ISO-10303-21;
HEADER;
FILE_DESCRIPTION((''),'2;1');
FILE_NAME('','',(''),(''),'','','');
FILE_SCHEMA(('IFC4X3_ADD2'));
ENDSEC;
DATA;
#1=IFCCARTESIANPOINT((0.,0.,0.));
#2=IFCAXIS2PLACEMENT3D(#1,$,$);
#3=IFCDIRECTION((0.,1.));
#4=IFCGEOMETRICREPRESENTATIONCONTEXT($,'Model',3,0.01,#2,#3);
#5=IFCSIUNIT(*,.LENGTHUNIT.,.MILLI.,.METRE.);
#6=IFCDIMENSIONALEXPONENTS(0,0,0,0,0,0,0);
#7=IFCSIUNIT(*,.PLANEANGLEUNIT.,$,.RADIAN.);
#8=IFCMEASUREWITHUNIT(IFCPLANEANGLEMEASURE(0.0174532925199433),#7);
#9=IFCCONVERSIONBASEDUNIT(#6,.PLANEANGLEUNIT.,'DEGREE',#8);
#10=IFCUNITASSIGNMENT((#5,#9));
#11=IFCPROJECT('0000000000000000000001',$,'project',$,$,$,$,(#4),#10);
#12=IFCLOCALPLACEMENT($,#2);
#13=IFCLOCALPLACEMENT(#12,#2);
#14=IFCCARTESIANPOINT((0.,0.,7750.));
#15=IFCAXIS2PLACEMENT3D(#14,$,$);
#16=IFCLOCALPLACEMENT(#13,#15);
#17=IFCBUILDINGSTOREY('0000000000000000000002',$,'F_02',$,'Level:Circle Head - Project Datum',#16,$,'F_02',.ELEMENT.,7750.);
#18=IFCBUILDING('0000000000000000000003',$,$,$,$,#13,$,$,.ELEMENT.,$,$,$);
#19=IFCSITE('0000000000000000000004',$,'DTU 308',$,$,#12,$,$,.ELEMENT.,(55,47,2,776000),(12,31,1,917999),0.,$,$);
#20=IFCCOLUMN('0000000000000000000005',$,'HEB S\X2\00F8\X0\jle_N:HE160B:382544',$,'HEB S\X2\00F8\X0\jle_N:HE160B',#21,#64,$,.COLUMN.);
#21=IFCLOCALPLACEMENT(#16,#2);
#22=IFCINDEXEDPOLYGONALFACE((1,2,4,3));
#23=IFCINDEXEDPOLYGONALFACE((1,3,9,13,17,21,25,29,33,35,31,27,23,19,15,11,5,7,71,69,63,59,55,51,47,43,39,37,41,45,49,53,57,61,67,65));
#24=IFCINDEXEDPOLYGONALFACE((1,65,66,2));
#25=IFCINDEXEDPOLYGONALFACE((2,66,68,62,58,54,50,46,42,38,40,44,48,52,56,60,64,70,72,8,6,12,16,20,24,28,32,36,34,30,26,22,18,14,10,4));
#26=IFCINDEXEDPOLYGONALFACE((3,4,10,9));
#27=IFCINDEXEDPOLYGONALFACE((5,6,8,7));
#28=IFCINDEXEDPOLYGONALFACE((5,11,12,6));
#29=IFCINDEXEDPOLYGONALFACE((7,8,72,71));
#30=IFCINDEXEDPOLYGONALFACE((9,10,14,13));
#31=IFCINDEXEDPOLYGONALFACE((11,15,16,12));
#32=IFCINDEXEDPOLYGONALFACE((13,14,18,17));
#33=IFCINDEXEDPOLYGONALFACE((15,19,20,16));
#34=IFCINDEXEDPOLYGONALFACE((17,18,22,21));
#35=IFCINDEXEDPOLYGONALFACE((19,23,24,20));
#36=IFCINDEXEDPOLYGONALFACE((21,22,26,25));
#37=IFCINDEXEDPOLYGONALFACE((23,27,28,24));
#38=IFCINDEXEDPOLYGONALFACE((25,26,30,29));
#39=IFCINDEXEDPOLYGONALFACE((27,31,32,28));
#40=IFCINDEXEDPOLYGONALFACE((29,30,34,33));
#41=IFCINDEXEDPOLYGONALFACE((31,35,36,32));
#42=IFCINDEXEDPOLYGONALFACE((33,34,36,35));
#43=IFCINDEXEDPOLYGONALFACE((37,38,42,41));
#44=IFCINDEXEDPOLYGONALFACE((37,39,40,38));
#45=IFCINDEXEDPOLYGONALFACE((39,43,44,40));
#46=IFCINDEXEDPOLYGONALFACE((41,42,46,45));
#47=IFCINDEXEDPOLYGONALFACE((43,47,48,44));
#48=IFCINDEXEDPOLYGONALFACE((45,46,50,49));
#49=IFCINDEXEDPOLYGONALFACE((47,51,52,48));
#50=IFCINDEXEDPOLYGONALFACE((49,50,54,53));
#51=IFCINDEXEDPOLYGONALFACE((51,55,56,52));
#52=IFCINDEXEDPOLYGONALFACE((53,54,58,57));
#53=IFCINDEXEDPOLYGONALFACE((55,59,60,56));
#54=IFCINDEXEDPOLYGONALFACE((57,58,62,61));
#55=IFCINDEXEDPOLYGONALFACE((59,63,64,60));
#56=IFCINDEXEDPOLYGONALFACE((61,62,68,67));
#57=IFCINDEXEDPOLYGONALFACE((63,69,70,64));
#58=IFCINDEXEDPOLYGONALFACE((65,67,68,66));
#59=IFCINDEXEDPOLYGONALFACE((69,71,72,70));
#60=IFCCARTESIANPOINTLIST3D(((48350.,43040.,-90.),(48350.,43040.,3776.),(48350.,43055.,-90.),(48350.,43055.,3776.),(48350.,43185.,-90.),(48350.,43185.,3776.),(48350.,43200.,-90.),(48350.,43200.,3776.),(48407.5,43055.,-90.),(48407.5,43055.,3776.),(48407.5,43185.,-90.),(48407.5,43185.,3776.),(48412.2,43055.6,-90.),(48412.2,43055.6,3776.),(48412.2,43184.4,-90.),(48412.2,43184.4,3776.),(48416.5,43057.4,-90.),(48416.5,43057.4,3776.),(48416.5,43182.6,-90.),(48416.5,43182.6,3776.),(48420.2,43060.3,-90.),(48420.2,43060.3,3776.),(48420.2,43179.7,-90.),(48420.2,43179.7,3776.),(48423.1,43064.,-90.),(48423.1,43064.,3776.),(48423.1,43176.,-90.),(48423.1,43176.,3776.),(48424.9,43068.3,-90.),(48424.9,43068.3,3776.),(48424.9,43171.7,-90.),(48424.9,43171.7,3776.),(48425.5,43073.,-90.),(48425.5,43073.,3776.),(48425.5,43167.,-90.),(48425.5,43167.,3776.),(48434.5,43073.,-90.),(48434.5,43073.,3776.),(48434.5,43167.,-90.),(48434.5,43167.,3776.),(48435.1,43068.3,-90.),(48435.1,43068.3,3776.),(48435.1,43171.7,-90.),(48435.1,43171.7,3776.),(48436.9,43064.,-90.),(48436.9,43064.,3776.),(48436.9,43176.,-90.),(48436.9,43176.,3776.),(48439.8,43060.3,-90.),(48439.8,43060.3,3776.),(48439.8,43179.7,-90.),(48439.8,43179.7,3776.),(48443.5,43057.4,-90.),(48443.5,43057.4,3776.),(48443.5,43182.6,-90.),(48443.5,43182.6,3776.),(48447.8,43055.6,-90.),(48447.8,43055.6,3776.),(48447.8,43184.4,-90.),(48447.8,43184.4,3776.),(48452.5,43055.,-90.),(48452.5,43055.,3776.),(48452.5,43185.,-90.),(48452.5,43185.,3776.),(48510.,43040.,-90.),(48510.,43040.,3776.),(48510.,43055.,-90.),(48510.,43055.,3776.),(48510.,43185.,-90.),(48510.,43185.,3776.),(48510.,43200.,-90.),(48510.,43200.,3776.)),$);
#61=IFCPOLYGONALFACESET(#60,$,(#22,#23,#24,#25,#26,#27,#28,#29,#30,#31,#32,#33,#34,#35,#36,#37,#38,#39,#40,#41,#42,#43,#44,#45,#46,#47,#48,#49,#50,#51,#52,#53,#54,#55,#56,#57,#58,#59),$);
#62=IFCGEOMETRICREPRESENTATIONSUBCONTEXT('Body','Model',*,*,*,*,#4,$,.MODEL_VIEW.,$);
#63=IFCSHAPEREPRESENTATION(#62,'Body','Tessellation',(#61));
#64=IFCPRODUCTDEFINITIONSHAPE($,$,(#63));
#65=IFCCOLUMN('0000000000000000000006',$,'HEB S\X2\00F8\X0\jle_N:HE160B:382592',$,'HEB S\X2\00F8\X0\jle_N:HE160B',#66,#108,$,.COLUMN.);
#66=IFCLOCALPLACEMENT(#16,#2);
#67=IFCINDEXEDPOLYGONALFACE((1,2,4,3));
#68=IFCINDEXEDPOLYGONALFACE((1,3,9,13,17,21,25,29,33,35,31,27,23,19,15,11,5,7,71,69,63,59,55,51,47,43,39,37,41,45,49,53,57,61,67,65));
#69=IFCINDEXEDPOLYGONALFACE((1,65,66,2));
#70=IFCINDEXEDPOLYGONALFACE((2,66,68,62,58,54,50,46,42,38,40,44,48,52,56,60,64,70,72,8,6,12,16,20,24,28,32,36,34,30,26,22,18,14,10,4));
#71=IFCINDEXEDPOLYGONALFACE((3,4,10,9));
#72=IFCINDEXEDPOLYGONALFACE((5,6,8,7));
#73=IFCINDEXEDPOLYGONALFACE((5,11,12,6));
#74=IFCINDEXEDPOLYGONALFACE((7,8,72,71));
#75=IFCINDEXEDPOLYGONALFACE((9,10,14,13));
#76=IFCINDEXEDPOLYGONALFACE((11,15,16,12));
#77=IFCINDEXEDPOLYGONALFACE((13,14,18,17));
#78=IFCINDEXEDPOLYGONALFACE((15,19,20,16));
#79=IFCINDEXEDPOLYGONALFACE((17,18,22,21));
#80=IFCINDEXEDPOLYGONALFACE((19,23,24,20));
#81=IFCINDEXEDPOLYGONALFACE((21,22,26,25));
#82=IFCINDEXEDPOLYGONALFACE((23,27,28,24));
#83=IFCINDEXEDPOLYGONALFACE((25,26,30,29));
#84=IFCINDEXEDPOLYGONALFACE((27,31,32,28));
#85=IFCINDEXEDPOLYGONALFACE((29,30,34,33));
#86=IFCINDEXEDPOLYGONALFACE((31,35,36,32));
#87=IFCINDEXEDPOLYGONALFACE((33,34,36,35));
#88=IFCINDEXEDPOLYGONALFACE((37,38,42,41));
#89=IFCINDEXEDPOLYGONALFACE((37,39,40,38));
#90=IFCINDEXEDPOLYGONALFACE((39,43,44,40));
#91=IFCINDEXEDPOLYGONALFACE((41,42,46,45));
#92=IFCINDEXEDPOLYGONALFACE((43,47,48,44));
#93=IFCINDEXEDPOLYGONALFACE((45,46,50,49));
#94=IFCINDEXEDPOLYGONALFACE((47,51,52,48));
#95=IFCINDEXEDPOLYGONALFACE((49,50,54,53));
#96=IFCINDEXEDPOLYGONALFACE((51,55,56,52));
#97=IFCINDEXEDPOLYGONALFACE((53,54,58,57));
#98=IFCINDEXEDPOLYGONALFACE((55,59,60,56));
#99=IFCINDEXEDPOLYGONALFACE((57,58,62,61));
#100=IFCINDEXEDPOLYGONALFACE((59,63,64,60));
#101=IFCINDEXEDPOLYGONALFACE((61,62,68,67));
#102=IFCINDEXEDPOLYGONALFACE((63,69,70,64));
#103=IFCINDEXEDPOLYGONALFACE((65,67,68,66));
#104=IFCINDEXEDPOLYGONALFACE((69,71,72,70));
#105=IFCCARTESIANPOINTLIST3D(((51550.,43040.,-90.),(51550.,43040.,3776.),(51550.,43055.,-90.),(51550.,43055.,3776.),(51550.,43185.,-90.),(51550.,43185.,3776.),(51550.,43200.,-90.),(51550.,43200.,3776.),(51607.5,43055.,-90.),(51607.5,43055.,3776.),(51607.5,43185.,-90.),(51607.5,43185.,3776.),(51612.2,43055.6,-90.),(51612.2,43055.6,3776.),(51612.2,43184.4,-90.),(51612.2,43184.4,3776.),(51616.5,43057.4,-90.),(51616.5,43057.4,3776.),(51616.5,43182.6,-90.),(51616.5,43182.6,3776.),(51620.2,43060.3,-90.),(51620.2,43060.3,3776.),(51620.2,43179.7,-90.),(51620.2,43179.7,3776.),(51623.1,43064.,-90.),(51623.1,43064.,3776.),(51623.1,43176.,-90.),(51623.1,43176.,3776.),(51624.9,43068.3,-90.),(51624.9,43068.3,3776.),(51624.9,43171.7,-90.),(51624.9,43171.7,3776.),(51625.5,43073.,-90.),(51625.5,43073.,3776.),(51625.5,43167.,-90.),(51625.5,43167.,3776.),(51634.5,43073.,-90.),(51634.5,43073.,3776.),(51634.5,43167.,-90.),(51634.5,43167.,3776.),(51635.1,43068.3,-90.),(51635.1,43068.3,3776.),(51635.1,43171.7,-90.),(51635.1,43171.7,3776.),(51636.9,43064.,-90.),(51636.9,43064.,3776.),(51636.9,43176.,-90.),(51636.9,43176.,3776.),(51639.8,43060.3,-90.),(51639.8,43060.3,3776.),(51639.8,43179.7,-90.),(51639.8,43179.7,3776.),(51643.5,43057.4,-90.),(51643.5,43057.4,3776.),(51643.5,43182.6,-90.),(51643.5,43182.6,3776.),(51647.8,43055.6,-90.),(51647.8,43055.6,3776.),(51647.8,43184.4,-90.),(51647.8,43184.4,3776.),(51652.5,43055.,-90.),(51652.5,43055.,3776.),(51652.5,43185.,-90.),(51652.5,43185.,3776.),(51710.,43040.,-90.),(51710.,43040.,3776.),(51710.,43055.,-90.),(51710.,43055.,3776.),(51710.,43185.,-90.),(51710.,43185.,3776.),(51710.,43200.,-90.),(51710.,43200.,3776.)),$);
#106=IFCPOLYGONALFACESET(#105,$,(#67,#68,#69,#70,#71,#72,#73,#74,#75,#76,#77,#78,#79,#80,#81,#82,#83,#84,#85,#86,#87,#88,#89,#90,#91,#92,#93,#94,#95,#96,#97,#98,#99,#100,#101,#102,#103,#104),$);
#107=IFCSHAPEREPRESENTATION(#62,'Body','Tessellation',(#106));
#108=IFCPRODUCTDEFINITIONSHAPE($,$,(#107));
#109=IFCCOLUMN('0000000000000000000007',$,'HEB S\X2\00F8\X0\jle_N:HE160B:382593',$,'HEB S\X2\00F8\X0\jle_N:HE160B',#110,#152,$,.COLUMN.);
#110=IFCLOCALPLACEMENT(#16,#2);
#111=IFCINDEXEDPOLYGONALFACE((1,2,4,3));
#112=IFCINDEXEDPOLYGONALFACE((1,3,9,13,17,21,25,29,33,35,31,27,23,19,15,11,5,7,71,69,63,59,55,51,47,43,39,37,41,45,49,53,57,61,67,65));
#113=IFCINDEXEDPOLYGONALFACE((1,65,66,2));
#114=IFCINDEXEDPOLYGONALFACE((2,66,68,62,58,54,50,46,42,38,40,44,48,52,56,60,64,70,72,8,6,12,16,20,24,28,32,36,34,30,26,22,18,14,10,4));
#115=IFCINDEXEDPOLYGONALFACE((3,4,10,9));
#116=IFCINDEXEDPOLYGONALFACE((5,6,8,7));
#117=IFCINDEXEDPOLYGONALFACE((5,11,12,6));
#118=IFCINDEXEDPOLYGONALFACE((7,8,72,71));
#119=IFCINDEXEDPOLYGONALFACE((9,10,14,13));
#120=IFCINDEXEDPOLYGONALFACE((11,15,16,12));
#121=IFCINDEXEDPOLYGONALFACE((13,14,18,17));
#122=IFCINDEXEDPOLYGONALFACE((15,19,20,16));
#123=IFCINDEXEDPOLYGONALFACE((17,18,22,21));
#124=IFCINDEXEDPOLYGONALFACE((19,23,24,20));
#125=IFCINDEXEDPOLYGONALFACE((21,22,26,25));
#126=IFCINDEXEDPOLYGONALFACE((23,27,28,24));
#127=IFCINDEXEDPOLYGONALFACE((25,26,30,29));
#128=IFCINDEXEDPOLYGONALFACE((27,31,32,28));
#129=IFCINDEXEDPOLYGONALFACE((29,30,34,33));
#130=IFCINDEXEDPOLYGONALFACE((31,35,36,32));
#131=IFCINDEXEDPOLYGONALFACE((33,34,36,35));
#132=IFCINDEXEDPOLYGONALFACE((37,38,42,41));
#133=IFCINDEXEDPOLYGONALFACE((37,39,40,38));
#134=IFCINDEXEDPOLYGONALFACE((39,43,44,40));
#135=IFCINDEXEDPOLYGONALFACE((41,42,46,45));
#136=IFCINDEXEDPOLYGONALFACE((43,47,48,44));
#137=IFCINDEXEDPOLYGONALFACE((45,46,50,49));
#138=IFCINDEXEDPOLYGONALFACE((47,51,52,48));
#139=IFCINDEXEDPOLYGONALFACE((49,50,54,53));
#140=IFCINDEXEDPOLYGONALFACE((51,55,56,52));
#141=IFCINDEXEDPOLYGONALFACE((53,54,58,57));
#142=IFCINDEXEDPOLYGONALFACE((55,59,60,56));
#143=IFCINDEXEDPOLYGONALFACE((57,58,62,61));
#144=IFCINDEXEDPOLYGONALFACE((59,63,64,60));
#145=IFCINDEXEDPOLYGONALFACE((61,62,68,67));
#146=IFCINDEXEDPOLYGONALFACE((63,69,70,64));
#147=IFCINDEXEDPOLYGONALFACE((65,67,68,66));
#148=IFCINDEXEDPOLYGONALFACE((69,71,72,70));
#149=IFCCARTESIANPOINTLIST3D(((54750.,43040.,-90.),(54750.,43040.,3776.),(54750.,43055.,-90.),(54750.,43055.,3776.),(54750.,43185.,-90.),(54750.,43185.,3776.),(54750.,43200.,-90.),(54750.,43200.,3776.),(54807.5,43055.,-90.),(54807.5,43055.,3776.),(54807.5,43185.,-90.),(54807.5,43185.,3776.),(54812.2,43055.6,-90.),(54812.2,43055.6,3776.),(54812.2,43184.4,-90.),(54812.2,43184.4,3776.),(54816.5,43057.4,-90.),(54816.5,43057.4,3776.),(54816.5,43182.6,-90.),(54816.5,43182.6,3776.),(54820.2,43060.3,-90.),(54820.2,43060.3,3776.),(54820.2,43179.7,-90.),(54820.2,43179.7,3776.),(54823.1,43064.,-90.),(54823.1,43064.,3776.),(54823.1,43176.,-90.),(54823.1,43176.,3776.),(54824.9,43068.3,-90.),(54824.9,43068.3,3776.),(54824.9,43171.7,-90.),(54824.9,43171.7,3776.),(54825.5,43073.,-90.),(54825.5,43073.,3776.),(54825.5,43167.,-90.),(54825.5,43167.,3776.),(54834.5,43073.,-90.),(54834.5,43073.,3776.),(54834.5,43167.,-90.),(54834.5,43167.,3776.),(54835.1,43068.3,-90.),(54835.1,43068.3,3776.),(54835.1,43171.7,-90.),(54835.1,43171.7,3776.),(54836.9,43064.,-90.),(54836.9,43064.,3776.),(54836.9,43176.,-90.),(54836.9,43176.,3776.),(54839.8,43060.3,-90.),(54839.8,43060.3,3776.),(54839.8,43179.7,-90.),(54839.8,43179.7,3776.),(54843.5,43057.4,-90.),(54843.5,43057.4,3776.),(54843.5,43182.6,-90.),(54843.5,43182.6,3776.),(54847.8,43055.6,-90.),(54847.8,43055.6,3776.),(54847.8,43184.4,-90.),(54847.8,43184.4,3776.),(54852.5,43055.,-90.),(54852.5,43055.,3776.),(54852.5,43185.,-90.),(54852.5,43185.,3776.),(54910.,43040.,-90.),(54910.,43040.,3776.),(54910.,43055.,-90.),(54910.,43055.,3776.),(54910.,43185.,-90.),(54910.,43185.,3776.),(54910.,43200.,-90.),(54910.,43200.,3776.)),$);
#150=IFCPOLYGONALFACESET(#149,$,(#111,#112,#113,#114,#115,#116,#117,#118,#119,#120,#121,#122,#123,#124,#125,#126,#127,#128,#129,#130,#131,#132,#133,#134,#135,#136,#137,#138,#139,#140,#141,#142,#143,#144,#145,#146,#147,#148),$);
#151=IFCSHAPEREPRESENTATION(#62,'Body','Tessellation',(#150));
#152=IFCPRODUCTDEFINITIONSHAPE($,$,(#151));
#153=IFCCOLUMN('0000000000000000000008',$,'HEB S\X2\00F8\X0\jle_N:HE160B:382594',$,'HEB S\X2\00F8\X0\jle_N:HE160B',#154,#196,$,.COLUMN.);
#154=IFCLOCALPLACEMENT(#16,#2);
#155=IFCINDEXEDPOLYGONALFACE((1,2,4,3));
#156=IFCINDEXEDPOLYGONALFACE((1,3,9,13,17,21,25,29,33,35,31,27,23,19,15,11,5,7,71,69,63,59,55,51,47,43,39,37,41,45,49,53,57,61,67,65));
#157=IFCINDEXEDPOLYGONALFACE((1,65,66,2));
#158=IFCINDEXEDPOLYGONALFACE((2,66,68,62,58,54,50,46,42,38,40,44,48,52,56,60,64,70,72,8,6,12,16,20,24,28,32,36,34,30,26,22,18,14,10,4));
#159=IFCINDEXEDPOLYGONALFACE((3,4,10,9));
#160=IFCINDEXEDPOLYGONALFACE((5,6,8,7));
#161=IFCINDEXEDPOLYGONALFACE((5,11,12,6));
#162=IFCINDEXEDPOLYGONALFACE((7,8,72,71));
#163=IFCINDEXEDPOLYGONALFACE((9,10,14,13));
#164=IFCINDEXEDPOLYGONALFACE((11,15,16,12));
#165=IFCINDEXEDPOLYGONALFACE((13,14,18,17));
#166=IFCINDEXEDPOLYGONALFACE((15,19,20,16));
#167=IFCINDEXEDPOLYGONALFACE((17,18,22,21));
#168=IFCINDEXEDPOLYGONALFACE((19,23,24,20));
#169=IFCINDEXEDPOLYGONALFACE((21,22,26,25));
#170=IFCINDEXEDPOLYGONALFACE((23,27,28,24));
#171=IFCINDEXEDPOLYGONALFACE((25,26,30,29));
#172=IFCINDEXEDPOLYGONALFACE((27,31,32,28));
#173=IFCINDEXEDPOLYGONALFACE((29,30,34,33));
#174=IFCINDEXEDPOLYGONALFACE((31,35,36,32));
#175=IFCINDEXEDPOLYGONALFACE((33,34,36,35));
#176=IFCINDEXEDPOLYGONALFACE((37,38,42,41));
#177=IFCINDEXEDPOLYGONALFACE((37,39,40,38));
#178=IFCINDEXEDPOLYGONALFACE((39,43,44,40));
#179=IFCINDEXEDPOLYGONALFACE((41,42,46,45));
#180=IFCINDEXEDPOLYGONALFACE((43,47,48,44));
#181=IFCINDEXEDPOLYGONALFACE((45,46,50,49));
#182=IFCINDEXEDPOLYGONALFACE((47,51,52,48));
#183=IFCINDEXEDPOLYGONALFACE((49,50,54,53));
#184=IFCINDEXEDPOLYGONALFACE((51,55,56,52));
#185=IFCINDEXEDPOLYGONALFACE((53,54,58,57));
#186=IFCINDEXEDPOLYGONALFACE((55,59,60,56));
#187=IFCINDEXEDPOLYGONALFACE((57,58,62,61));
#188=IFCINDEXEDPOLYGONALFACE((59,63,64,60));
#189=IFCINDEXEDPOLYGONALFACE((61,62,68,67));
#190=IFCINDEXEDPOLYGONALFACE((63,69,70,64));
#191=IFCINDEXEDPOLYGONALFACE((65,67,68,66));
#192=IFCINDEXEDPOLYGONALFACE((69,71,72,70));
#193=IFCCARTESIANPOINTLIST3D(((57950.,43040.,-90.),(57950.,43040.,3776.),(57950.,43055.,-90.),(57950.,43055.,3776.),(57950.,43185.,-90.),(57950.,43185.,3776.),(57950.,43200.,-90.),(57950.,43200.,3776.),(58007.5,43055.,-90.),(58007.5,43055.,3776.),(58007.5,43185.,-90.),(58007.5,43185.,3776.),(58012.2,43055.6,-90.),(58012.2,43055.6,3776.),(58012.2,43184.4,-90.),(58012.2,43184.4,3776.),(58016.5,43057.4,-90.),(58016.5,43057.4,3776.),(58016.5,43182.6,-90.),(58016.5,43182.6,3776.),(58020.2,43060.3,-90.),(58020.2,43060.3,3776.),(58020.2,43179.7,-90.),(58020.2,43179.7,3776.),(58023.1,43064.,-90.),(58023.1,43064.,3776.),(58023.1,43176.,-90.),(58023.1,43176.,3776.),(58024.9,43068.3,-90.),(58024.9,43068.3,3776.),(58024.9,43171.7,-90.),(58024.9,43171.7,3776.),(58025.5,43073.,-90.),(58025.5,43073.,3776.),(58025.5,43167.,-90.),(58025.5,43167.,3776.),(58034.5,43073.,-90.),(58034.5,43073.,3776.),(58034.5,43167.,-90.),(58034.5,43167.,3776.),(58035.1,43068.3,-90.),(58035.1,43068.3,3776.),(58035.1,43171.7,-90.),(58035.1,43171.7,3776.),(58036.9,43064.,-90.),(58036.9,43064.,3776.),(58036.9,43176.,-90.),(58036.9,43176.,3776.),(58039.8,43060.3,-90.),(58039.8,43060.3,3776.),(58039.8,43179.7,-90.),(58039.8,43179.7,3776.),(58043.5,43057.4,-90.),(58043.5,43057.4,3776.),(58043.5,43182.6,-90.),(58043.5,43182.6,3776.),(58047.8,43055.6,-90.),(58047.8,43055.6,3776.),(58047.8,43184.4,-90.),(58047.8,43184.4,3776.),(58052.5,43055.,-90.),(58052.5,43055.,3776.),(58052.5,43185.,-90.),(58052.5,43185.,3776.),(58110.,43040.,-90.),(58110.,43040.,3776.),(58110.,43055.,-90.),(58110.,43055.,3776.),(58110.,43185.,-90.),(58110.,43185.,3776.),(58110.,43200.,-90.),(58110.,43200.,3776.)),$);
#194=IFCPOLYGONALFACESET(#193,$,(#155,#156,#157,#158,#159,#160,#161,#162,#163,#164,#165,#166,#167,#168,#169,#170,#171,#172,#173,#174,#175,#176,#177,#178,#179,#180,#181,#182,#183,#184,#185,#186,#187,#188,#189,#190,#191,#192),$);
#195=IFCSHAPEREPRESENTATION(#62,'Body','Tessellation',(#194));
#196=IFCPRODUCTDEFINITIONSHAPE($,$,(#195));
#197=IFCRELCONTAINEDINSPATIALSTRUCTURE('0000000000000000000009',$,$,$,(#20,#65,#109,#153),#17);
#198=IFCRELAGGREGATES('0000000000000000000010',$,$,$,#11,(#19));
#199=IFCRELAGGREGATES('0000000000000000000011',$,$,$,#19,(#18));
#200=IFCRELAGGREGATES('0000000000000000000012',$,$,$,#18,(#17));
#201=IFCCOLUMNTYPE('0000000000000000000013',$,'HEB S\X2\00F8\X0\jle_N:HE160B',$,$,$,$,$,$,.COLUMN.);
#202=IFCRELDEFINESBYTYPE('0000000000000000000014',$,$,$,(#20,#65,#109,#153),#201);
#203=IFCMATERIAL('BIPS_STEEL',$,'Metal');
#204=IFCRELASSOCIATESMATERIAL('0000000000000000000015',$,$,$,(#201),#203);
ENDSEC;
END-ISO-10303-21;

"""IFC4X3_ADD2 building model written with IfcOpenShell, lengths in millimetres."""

from ifc_helpers import new_model, entity, si_unit, converted_unit, direction, frame, frame_2d, origin, place, context, subcontext, project, spatial, i_section, extrude, source, transform, mapped, material, material_profile, profile_set, type_object, element, save


model = new_model("IFC4X3_ADD2")

# Units and contexts
model_context = context("Model", 3, precision=0.01, world=origin(), true_north=direction((0.0, 1.0)))
body_context = subcontext(model_context, "Body", "Model", "MODEL_VIEW")
ifc_project = project(units=[si_unit("LENGTHUNIT", "METRE", prefix="MILLI"), converted_unit("PLANEANGLEUNIT", "DEGREE", entity("IfcPlaneAngleMeasure", 0.0174532925199433), si_unit("PLANEANGLEUNIT", "RADIAN"), dimensions=[0, 0, 0, 0, 0, 0, 0])], contexts=[model_context])

# Site, building, storey
site_placement = place(None, origin())
site = spatial("IfcSite", under=ifc_project, at=site_placement, Name="DTU 308", CompositionType="ELEMENT", RefLatitude=(55, 47, 2, 776000), RefLongitude=(12, 31, 1, 917999), RefElevation=0.0)
building_placement = place(site_placement, origin())
building = spatial("IfcBuilding", under=site, at=building_placement, CompositionType="ELEMENT")
storey_placement = place(building_placement, frame((0.0, 0.0, 7750.0)))
storey = spatial("IfcBuildingStorey", under=building, at=storey_placement, Name="F_02", ObjectType="Level:Circle Head - Project Datum", LongName="F_02", CompositionType="ELEMENT", Elevation=7750.0)

# Columns
ifc_material = material(Name="BIPS_STEEL", Category="Metal")
ifc_material_profile_1 = material_profile(ifc_material, i_section(OverallWidth=160.0, OverallDepth=160.0, WebThickness=9.0, FlangeThickness=15.0, FilletRadius=18.0, at=frame_2d((0.0, 0.0), x_axis=(1.0, 0.0))), Name="HE160B")
ifc_profile_set_1 = profile_set([ifc_material_profile_1], Name="HE160B")
column_type_1 = type_object("IfcColumnType", Name="HEB Søjle_N:HE160B", PredefinedType="COLUMN", material=ifc_profile_set_1)
shared_shape_1 = source(origin(), body_context, "Body", "SweptSolid", [
    extrude(i_section(OverallWidth=160.0, OverallDepth=160.0, WebThickness=9.0, FlangeThickness=15.0, FilletRadius=18.0, at=frame_2d((0.0, 0.0), x_axis=(1.0, 0.0))), frame((0.0, 0.0, 7660.0), z_axis=(0.0, 0.0, 1.0), x_axis=(-1.0, 0.0, 0.0)), (0.0, 0.0, 1.0), 3866.0),
])
for number, where, name in (
    (1, (48430.0, 43120.0, -7750.0), "HEB Søjle_N:HE160B:382544"),
    (2, (51630.0, 43120.0, -7750.0), "HEB Søjle_N:HE160B:382592"),
    (3, (54830.0, 43120.0, -7750.0), "HEB Søjle_N:HE160B:382593"),
    (4, (58030.0, 43120.0, -7750.0), "HEB Søjle_N:HE160B:382594"),
):
    element("IfcColumn", number, at=place(storey_placement, frame(where)), inside=storey, type_object=column_type_1, Name=name, ObjectType="HEB Søjle_N:HE160B", PredefinedType="COLUMN", context=body_context, shape_type="MappedRepresentation", body=[
        mapped(shared_shape_1, transform((0.0, 0.0, 0.0), scale=1.0)),
    ])

save(model, "model.ifc")
